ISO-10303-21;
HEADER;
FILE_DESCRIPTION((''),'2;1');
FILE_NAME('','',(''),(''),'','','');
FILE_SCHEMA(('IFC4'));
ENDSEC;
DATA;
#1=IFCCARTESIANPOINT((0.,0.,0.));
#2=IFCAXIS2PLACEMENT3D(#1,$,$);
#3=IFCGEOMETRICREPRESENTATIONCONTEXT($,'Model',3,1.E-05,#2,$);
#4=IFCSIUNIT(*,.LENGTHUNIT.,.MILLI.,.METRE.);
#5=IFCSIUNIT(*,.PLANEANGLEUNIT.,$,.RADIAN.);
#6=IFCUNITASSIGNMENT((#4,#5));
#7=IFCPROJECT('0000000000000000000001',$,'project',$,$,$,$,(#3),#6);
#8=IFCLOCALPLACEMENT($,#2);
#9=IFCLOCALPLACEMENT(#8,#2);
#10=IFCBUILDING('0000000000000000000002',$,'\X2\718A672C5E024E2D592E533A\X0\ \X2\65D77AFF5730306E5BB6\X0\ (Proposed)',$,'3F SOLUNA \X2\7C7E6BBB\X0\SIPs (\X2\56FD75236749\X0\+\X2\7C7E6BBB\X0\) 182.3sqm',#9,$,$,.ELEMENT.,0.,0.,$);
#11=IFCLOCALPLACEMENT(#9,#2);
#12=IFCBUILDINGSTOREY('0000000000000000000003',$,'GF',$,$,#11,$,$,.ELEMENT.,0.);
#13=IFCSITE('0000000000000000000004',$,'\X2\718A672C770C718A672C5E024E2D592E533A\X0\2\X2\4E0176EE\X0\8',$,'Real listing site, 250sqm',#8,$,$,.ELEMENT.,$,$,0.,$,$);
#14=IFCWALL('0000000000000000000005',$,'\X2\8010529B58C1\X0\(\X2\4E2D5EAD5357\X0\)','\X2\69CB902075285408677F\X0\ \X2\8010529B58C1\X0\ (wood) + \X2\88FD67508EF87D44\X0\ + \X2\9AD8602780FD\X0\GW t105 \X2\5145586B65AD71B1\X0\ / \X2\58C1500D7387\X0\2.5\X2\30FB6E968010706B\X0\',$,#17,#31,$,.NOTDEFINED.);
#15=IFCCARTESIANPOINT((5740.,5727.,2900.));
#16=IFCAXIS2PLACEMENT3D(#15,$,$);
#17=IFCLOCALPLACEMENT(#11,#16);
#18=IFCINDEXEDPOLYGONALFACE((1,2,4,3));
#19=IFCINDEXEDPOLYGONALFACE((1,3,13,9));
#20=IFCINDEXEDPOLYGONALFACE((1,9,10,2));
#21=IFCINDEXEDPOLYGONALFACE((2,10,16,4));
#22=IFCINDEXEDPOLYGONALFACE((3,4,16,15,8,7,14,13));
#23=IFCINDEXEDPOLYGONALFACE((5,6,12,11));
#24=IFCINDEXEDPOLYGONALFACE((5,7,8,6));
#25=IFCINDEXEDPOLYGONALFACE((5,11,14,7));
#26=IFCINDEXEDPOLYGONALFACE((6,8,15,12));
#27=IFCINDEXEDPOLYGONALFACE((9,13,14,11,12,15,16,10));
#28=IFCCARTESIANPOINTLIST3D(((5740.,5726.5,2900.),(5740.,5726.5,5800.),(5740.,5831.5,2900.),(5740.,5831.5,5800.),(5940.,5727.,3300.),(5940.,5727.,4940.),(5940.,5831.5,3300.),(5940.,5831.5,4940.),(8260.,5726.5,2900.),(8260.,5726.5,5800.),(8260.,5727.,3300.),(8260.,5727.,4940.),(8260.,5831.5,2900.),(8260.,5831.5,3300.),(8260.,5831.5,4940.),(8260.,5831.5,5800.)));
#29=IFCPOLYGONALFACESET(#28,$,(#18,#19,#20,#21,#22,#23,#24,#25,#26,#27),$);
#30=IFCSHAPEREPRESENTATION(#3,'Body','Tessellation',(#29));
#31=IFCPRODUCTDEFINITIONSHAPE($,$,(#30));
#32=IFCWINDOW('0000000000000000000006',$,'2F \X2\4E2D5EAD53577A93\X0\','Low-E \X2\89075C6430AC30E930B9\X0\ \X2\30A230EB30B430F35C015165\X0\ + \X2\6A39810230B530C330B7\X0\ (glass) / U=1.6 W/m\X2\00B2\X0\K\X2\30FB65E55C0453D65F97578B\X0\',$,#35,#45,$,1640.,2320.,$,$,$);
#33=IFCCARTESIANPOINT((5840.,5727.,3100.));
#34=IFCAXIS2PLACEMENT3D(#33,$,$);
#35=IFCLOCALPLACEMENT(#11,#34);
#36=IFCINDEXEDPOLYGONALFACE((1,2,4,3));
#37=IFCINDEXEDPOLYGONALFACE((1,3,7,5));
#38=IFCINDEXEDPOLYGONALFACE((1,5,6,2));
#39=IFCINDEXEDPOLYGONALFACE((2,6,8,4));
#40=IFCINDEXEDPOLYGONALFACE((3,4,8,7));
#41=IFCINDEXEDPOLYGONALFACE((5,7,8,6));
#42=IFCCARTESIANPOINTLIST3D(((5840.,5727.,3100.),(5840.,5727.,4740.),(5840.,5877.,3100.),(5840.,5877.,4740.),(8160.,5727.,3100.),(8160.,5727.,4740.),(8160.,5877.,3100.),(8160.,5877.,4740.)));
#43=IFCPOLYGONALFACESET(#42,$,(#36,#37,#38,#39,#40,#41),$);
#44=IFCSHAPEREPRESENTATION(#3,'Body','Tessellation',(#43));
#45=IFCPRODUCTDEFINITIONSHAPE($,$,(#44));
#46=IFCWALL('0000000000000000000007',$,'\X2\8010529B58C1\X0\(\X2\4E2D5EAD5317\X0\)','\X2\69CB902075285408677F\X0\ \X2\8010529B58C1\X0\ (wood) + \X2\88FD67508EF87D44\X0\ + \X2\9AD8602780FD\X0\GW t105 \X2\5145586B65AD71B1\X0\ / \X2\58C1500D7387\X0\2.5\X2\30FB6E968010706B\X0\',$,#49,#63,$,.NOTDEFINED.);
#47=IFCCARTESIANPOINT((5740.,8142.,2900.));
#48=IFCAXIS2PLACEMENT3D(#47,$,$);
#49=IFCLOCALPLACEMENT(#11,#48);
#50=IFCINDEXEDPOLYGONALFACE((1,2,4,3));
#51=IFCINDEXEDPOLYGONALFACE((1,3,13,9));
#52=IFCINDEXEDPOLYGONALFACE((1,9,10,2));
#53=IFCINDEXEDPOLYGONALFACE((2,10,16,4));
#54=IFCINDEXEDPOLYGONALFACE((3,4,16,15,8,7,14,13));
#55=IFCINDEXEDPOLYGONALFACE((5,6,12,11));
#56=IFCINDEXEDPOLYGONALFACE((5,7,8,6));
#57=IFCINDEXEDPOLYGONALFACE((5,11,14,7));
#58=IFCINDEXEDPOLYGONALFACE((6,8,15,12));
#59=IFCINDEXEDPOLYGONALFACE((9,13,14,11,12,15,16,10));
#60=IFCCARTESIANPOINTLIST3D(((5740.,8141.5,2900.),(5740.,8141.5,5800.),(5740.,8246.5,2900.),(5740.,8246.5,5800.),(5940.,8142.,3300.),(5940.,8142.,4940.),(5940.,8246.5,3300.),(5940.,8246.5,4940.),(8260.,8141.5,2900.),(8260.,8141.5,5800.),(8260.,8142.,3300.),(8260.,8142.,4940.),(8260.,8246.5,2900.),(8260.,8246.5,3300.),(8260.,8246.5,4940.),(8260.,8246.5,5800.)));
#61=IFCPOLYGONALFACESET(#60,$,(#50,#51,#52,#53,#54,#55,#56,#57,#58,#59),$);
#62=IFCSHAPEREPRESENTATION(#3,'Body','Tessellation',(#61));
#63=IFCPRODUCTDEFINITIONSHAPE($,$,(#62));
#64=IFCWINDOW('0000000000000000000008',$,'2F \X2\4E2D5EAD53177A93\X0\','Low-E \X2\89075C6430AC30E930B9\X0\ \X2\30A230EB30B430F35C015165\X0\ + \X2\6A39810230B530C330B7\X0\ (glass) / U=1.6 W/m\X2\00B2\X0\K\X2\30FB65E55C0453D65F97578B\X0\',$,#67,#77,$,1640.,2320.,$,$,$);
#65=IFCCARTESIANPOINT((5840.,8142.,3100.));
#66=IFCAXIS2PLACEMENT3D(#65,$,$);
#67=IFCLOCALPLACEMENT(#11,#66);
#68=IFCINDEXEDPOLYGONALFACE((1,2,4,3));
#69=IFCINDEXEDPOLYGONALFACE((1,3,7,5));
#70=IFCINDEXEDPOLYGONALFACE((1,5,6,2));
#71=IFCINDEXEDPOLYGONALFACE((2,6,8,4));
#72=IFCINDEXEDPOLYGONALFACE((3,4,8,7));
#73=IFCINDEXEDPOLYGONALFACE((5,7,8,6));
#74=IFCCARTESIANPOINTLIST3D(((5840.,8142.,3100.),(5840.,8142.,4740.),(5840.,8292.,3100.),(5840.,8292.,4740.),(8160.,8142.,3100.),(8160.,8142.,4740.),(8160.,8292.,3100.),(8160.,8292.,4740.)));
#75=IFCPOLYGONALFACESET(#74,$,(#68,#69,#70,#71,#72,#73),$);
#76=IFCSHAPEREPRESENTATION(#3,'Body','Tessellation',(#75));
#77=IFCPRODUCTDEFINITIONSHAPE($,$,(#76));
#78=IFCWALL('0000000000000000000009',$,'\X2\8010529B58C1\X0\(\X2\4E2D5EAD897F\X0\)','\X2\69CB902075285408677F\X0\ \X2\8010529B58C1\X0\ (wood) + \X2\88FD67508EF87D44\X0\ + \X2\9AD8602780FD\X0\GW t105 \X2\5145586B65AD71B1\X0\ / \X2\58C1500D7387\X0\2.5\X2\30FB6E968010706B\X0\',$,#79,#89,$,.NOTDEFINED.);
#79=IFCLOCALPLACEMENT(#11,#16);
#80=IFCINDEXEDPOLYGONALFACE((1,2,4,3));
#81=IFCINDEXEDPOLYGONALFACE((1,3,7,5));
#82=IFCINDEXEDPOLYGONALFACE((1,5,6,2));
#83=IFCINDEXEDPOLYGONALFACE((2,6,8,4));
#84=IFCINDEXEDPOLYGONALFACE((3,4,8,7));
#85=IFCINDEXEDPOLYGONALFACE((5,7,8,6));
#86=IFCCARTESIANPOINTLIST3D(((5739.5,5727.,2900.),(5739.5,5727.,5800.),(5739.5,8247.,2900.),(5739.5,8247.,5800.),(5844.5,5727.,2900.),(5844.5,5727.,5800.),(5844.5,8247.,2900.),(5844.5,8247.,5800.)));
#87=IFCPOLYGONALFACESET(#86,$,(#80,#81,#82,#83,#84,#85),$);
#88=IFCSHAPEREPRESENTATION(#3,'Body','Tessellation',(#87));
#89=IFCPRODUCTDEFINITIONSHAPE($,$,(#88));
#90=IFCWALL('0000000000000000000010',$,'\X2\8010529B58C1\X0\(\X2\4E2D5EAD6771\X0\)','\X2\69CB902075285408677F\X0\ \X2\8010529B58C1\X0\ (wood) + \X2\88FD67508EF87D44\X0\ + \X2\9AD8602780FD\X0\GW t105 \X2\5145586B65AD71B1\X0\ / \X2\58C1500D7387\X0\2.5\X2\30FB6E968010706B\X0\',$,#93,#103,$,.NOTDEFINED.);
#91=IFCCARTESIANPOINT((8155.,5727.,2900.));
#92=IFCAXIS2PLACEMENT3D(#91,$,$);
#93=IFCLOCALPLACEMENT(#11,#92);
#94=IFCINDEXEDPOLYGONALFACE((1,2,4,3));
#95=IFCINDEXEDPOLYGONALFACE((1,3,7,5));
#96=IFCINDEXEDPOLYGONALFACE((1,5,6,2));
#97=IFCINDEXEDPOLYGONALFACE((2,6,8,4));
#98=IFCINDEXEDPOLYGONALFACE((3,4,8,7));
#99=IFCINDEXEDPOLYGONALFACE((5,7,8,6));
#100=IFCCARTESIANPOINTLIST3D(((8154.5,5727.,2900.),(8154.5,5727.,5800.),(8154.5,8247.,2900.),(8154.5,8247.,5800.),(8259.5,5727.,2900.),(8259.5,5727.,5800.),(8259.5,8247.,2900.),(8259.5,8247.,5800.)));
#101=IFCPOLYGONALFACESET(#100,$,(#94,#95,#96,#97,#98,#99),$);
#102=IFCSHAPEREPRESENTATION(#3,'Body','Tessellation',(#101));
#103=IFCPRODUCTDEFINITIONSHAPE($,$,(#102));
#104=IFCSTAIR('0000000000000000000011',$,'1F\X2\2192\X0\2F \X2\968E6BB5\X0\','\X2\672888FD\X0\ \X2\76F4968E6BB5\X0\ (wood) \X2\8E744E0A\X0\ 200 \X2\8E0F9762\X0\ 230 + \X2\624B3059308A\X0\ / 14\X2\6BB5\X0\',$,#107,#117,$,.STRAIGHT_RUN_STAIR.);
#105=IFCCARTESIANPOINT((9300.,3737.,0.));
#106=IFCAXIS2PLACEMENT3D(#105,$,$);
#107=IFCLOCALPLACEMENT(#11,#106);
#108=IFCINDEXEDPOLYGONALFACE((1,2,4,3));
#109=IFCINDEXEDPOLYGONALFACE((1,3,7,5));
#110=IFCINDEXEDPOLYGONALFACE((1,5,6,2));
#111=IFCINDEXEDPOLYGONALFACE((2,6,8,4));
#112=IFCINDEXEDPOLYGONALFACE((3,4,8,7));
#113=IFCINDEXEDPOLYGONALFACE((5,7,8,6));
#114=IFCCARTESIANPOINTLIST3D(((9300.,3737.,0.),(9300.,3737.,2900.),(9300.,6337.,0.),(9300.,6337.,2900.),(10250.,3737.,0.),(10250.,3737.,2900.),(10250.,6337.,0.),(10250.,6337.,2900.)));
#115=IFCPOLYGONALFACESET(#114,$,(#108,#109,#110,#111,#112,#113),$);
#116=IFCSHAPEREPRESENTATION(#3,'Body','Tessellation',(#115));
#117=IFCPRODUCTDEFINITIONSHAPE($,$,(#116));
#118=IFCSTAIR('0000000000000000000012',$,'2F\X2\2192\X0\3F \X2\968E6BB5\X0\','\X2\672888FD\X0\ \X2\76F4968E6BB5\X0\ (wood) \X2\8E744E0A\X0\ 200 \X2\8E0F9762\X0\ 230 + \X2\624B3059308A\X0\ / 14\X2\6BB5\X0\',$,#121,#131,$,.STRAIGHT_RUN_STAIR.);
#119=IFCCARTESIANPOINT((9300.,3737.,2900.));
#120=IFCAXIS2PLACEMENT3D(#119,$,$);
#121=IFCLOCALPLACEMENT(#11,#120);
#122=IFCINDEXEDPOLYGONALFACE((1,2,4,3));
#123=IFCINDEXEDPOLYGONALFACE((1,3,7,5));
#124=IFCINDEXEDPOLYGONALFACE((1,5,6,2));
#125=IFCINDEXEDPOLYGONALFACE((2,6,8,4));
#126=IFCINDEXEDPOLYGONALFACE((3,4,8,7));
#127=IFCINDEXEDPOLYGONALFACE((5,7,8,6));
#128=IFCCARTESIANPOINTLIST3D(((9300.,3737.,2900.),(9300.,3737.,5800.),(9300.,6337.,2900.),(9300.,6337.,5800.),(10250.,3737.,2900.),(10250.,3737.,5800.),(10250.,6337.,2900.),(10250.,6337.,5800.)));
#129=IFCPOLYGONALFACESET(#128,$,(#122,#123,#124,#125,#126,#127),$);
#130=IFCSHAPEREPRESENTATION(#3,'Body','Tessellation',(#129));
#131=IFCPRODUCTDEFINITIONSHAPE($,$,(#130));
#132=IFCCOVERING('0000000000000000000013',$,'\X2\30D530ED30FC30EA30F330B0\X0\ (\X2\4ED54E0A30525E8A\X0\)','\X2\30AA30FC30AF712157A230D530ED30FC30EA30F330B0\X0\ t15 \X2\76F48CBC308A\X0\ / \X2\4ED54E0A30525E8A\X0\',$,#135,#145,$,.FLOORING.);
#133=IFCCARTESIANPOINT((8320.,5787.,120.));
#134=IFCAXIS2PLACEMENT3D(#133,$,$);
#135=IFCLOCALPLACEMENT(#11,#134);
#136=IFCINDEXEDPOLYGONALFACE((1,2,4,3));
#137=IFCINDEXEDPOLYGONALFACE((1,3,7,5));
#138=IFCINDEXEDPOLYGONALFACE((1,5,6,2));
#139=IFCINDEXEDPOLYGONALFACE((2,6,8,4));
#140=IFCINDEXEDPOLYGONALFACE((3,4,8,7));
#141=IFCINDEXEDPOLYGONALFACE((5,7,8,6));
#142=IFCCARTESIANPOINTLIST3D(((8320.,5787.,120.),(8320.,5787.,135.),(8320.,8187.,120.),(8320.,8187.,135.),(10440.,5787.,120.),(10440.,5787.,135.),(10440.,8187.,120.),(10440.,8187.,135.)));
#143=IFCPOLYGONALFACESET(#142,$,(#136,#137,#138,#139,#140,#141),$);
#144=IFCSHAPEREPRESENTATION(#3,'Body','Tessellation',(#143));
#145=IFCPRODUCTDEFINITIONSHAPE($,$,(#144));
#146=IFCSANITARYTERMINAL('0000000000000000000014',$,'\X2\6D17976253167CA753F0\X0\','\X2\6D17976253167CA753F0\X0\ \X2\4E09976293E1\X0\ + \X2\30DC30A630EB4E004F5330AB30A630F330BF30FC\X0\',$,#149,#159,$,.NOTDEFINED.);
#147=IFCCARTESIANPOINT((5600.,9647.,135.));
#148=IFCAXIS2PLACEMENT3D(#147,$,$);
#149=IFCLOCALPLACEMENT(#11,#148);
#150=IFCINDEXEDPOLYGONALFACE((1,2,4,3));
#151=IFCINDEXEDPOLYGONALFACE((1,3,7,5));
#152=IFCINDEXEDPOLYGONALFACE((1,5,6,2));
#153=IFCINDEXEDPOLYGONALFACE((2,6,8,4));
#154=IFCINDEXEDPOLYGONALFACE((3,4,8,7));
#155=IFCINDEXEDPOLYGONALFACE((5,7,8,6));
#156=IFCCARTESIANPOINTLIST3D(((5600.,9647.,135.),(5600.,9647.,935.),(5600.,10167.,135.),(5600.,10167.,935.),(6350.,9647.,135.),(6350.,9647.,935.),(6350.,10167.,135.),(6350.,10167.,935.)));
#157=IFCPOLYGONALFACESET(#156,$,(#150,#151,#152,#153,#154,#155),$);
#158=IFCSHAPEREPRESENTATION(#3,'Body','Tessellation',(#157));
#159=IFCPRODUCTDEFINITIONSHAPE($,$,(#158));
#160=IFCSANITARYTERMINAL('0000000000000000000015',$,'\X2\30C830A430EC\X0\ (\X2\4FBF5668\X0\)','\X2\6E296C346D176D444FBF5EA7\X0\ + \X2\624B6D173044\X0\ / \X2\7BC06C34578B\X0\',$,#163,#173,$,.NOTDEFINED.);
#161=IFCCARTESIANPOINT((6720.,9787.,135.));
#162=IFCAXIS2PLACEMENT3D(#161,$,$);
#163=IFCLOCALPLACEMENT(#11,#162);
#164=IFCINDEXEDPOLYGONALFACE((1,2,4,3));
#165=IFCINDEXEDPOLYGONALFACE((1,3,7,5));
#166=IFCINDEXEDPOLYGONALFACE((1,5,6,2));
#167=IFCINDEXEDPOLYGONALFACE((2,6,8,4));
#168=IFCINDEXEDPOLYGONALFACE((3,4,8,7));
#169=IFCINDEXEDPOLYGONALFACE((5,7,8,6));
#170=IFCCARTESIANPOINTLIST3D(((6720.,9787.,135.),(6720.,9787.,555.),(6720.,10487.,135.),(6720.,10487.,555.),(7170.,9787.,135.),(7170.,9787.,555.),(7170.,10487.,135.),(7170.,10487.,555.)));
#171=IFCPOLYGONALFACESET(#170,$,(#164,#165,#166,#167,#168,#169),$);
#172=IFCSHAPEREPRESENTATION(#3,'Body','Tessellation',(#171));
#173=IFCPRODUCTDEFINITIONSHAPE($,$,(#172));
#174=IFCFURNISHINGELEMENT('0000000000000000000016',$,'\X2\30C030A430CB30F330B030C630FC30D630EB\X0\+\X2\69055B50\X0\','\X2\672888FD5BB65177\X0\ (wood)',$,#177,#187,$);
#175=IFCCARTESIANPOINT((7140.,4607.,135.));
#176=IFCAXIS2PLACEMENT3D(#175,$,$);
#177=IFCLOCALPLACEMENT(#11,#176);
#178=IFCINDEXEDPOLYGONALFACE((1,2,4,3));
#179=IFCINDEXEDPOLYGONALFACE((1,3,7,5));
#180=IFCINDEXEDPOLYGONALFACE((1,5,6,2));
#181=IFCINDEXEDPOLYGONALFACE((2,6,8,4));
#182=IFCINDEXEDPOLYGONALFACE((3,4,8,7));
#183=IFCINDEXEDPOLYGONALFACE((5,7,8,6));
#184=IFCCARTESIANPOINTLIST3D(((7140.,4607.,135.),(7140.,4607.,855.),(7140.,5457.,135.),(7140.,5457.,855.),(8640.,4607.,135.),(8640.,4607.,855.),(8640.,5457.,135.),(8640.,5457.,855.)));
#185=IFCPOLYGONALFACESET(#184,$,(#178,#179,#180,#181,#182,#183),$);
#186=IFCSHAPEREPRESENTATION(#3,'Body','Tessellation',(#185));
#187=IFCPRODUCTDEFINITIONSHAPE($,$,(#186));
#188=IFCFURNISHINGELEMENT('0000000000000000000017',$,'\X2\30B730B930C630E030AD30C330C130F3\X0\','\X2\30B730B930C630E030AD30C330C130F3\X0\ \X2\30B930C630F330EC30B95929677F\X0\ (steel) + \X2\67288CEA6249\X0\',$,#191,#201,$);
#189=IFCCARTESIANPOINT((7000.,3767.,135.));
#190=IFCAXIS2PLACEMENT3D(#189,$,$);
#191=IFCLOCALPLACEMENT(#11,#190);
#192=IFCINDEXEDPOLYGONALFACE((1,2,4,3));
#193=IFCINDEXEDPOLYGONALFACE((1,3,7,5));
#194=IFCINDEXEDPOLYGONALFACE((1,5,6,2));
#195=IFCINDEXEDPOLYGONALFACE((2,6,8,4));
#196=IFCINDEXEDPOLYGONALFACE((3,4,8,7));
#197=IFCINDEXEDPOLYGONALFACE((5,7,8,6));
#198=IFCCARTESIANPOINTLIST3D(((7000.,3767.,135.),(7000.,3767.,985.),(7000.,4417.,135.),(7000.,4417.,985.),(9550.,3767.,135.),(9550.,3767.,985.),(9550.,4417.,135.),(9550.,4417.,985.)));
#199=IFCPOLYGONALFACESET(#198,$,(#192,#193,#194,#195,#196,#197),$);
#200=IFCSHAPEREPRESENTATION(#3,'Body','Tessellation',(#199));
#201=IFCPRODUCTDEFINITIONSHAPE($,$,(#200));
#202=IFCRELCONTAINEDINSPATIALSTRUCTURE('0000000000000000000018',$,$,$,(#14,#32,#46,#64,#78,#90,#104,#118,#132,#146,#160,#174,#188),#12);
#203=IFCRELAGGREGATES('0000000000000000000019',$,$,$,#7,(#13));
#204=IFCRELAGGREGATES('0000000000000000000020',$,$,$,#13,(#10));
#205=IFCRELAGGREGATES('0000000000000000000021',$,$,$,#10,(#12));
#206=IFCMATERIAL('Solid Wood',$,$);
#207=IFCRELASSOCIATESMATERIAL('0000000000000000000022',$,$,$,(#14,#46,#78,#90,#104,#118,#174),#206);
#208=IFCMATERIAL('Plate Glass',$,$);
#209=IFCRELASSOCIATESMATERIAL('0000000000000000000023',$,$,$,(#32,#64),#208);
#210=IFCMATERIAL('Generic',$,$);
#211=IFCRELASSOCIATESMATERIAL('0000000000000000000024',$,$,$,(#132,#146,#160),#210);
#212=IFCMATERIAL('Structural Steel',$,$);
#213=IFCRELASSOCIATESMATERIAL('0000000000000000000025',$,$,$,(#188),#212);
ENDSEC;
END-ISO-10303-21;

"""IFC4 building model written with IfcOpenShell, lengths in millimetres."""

from ifc_helpers import new_model, si_unit, frame, frame_2d, origin, place, context, project, spatial, rectangle, extrude, material, element, fill, save


model = new_model("IFC4")

# Units and contexts
model_context = context("Model", 3, precision=1e-05, world=origin())
ifc_project = project(units=[si_unit("LENGTHUNIT", "METRE", prefix="MILLI"), si_unit("PLANEANGLEUNIT", "RADIAN")], contexts=[model_context])

# Site, building, storey
site_placement = place(None, origin())
site = spatial("IfcSite", under=ifc_project, at=site_placement, Name="熊本県熊本市中央区2丁目8", ObjectType="Real listing site, 250sqm", CompositionType="ELEMENT", RefElevation=0.0)
building_placement = place(site_placement, origin())
building = spatial("IfcBuilding", under=site, at=building_placement, Name="熊本市中央区 旗竿地の家 (Proposed)", ObjectType="3F SOLUNA 籾殻SIPs (国産杉+籾殻) 182.3sqm", CompositionType="ELEMENT", ElevationOfRefHeight=0.0, ElevationOfTerrain=0.0)
storey_placement = place(building_placement, origin())
storey = spatial("IfcBuildingStorey", under=building, at=storey_placement, Name="GF", CompositionType="ELEMENT", Elevation=0.0)

# Shared definitions
ifc_material_1 = material(Name="Solid Wood")

# Shared definitions
ifc_material_2 = material(Name="Plate Glass")

# Walls, openings, windows
wall_1_placement = place(storey_placement, frame((5740.0, 5727.0, 2900.0)))
wall_1 = element("IfcWall", 1, at=wall_1_placement, inside=storey, material=ifc_material_1, Name="耐力壁(中庭南)", Description="構造用合板 耐力壁 (wood) + 製材軸組 + 高性能GW t105 充填断熱 / 壁倍率2.5・準耐火", PredefinedType="NOTDEFINED", context=model_context, shape_type="SweptSolid", body=[
    extrude(rectangle(XDim=2520.0, YDim=105.0, at=frame_2d((1260.0, 52.0))), frame((5740.0, 5727.0, 2900.0)), (0.0, 0.0, 1.0), 2900.0),
])
opening_1_placement = place(storey_placement, frame((5840.0, 5727.0, 3100.0)))
opening_1 = element("IfcOpeningElement", 2, at=opening_1_placement, cuts=wall_1, PredefinedType="NOTDEFINED", context=model_context, shape_type="SweptSolid", body=[
    extrude(rectangle(XDim=2320.0, YDim=150.0, at=frame_2d((1160.0, 75.0))), frame((5840.0, 5727.0, 3100.0)), (0.0, 0.0, 1.0), 1640.0),
])
window_1_placement = place(storey_placement, frame((5840.0, 5727.0, 3100.0)))
window_1 = element("IfcWindow", 3, at=window_1_placement, inside=storey, material=ifc_material_2, Name="2F 中庭南窓", Description="Low-E 複層ガラス アルゴン封入 + 樹脂サッシ (glass) / U=1.6 W/m²K・日射取得型", OverallHeight=1640.0, OverallWidth=2320.0, context=model_context, shape_type="SweptSolid", body=[
    extrude(rectangle(XDim=2320.0, YDim=150.0, at=frame_2d((1160.0, 75.0))), frame((5840.0, 5727.0, 3100.0)), (0.0, 0.0, 1.0), 1640.0),
])
fill(opening_1, window_1)
wall_2_placement = place(storey_placement, frame((5740.0, 8142.0, 2900.0)))
wall_2 = element("IfcWall", 4, at=wall_2_placement, inside=storey, material=ifc_material_1, Name="耐力壁(中庭北)", Description="構造用合板 耐力壁 (wood) + 製材軸組 + 高性能GW t105 充填断熱 / 壁倍率2.5・準耐火", PredefinedType="NOTDEFINED", context=model_context, shape_type="SweptSolid", body=[
    extrude(rectangle(XDim=2520.0, YDim=105.0, at=frame_2d((1260.0, 52.0))), frame((5740.0, 8142.0, 2900.0)), (0.0, 0.0, 1.0), 2900.0),
])
opening_2_placement = place(storey_placement, frame((5840.0, 8142.0, 3100.0)))
opening_2 = element("IfcOpeningElement", 5, at=opening_2_placement, cuts=wall_2, PredefinedType="NOTDEFINED", context=model_context, shape_type="SweptSolid", body=[
    extrude(rectangle(XDim=2320.0, YDim=150.0, at=frame_2d((1160.0, 75.0))), frame((5840.0, 8142.0, 3100.0)), (0.0, 0.0, 1.0), 1640.0),
])
window_2_placement = place(storey_placement, frame((5840.0, 8142.0, 3100.0)))
window_2 = element("IfcWindow", 6, at=window_2_placement, inside=storey, material=ifc_material_2, Name="2F 中庭北窓", Description="Low-E 複層ガラス アルゴン封入 + 樹脂サッシ (glass) / U=1.6 W/m²K・日射取得型", OverallHeight=1640.0, OverallWidth=2320.0, context=model_context, shape_type="SweptSolid", body=[
    extrude(rectangle(XDim=2320.0, YDim=150.0, at=frame_2d((1160.0, 75.0))), frame((5840.0, 8142.0, 3100.0)), (0.0, 0.0, 1.0), 1640.0),
])
fill(opening_2, window_2)

# Walls
wall_3_placement = place(storey_placement, frame((5740.0, 5727.0, 2900.0)))
element("IfcWall", 7, at=wall_3_placement, inside=storey, material=ifc_material_1, Name="耐力壁(中庭西)", Description="構造用合板 耐力壁 (wood) + 製材軸組 + 高性能GW t105 充填断熱 / 壁倍率2.5・準耐火", PredefinedType="NOTDEFINED", context=model_context, shape_type="SweptSolid", body=[
    extrude(rectangle(XDim=105.0, YDim=2520.0, at=frame_2d((52.0, 1260.0))), frame((5740.0, 5727.0, 2900.0)), (0.0, 0.0, 1.0), 2900.0),
])
wall_4_placement = place(storey_placement, frame((8155.0, 5727.0, 2900.0)))
element("IfcWall", 8, at=wall_4_placement, inside=storey, material=ifc_material_1, Name="耐力壁(中庭東)", Description="構造用合板 耐力壁 (wood) + 製材軸組 + 高性能GW t105 充填断熱 / 壁倍率2.5・準耐火", PredefinedType="NOTDEFINED", context=model_context, shape_type="SweptSolid", body=[
    extrude(rectangle(XDim=105.0, YDim=2520.0, at=frame_2d((52.0, 1260.0))), frame((8155.0, 5727.0, 2900.0)), (0.0, 0.0, 1.0), 2900.0),
])

# Stairs
stair_1_placement = place(storey_placement, frame((9300.0, 3737.0, 0.0)))
element("IfcStair", 9, at=stair_1_placement, inside=storey, material=ifc_material_1, Name="1F→2F 階段", Description="木製 直階段 (wood) 蹴上 200 踏面 230 + 手すり / 14段", PredefinedType="STRAIGHT_RUN_STAIR", context=model_context, shape_type="SweptSolid", body=[
    extrude(rectangle(XDim=950.0, YDim=2600.0, at=frame_2d((475.0, 1300.0))), frame((9300.0, 3737.0, 0.0)), (0.0, 0.0, 1.0), 2900.0),
])
stair_2_placement = place(storey_placement, frame((9300.0, 3737.0, 2900.0)))
element("IfcStair", 10, at=stair_2_placement, inside=storey, material=ifc_material_1, Name="2F→3F 階段", Description="木製 直階段 (wood) 蹴上 200 踏面 230 + 手すり / 14段", PredefinedType="STRAIGHT_RUN_STAIR", context=model_context, shape_type="SweptSolid", body=[
    extrude(rectangle(XDim=950.0, YDim=2600.0, at=frame_2d((475.0, 1300.0))), frame((9300.0, 3737.0, 2900.0)), (0.0, 0.0, 1.0), 2900.0),
])

# Covering
ifc_material_3 = material(Name="Generic")
covering_placement = place(storey_placement, frame((8320.0, 5787.0, 120.0)))
element("IfcCovering", 11, at=covering_placement, inside=storey, material=ifc_material_3, Name="フローリング (仕上げ床)", Description="オーク無垢フローリング t15 直貼り / 仕上げ床", PredefinedType="FLOORING", context=model_context, shape_type="SweptSolid", body=[
    extrude(rectangle(XDim=2120.0, YDim=2400.0, at=frame_2d((1060.0, 1200.0))), frame((8320.0, 5787.0, 120.0)), (0.0, 0.0, 1.0), 15.0),
])

# Sanitary terminals
sanitary_terminal_1_placement = place(storey_placement, frame((5600.0, 9647.0, 135.0)))
element("IfcSanitaryTerminal", 12, at=sanitary_terminal_1_placement, inside=storey, material=ifc_material_3, Name="洗面化粧台", Description="洗面化粧台 三面鏡 + ボウル一体カウンター", PredefinedType="NOTDEFINED", context=model_context, shape_type="SweptSolid", body=[
    extrude(rectangle(XDim=750.0, YDim=520.0, at=frame_2d((375.0, 260.0))), frame((5600.0, 9647.0, 135.0)), (0.0, 0.0, 1.0), 800.0),
])
sanitary_terminal_2_placement = place(storey_placement, frame((6720.0, 9787.0, 135.0)))
element("IfcSanitaryTerminal", 13, at=sanitary_terminal_2_placement, inside=storey, material=ifc_material_3, Name="トイレ (便器)", Description="温水洗浄便座 + 手洗い / 節水型", PredefinedType="NOTDEFINED", context=model_context, shape_type="SweptSolid", body=[
    extrude(rectangle(XDim=450.0, YDim=700.0, at=frame_2d((225.0, 350.0))), frame((6720.0, 9787.0, 135.0)), (0.0, 0.0, 1.0), 420.0),
])

# Furnishing elements
furnishing_1_placement = place(storey_placement, frame((7140.0, 4607.0, 135.0)))
element("IfcFurnishingElement", 14, at=furnishing_1_placement, inside=storey, material=ifc_material_1, Name="ダイニングテーブル+椅子", Description="木製家具 (wood)", context=model_context, shape_type="SweptSolid", body=[
    extrude(rectangle(XDim=1500.0, YDim=850.0, at=frame_2d((750.0, 425.0))), frame((7140.0, 4607.0, 135.0)), (0.0, 0.0, 1.0), 720.0),
])
ifc_material_4 = material(Name="Structural Steel")
furnishing_2_placement = place(storey_placement, frame((7000.0, 3767.0, 135.0)))
element("IfcFurnishingElement", 15, at=furnishing_2_placement, inside=storey, material=ifc_material_4, Name="システムキッチン", Description="システムキッチン ステンレス天板 (steel) + 木質扉", context=model_context, shape_type="SweptSolid", body=[
    extrude(rectangle(XDim=2550.0, YDim=650.0, at=frame_2d((1275.0, 325.0))), frame((7000.0, 3767.0, 135.0)), (0.0, 0.0, 1.0), 850.0),
])

save(model, "model.ifc")
